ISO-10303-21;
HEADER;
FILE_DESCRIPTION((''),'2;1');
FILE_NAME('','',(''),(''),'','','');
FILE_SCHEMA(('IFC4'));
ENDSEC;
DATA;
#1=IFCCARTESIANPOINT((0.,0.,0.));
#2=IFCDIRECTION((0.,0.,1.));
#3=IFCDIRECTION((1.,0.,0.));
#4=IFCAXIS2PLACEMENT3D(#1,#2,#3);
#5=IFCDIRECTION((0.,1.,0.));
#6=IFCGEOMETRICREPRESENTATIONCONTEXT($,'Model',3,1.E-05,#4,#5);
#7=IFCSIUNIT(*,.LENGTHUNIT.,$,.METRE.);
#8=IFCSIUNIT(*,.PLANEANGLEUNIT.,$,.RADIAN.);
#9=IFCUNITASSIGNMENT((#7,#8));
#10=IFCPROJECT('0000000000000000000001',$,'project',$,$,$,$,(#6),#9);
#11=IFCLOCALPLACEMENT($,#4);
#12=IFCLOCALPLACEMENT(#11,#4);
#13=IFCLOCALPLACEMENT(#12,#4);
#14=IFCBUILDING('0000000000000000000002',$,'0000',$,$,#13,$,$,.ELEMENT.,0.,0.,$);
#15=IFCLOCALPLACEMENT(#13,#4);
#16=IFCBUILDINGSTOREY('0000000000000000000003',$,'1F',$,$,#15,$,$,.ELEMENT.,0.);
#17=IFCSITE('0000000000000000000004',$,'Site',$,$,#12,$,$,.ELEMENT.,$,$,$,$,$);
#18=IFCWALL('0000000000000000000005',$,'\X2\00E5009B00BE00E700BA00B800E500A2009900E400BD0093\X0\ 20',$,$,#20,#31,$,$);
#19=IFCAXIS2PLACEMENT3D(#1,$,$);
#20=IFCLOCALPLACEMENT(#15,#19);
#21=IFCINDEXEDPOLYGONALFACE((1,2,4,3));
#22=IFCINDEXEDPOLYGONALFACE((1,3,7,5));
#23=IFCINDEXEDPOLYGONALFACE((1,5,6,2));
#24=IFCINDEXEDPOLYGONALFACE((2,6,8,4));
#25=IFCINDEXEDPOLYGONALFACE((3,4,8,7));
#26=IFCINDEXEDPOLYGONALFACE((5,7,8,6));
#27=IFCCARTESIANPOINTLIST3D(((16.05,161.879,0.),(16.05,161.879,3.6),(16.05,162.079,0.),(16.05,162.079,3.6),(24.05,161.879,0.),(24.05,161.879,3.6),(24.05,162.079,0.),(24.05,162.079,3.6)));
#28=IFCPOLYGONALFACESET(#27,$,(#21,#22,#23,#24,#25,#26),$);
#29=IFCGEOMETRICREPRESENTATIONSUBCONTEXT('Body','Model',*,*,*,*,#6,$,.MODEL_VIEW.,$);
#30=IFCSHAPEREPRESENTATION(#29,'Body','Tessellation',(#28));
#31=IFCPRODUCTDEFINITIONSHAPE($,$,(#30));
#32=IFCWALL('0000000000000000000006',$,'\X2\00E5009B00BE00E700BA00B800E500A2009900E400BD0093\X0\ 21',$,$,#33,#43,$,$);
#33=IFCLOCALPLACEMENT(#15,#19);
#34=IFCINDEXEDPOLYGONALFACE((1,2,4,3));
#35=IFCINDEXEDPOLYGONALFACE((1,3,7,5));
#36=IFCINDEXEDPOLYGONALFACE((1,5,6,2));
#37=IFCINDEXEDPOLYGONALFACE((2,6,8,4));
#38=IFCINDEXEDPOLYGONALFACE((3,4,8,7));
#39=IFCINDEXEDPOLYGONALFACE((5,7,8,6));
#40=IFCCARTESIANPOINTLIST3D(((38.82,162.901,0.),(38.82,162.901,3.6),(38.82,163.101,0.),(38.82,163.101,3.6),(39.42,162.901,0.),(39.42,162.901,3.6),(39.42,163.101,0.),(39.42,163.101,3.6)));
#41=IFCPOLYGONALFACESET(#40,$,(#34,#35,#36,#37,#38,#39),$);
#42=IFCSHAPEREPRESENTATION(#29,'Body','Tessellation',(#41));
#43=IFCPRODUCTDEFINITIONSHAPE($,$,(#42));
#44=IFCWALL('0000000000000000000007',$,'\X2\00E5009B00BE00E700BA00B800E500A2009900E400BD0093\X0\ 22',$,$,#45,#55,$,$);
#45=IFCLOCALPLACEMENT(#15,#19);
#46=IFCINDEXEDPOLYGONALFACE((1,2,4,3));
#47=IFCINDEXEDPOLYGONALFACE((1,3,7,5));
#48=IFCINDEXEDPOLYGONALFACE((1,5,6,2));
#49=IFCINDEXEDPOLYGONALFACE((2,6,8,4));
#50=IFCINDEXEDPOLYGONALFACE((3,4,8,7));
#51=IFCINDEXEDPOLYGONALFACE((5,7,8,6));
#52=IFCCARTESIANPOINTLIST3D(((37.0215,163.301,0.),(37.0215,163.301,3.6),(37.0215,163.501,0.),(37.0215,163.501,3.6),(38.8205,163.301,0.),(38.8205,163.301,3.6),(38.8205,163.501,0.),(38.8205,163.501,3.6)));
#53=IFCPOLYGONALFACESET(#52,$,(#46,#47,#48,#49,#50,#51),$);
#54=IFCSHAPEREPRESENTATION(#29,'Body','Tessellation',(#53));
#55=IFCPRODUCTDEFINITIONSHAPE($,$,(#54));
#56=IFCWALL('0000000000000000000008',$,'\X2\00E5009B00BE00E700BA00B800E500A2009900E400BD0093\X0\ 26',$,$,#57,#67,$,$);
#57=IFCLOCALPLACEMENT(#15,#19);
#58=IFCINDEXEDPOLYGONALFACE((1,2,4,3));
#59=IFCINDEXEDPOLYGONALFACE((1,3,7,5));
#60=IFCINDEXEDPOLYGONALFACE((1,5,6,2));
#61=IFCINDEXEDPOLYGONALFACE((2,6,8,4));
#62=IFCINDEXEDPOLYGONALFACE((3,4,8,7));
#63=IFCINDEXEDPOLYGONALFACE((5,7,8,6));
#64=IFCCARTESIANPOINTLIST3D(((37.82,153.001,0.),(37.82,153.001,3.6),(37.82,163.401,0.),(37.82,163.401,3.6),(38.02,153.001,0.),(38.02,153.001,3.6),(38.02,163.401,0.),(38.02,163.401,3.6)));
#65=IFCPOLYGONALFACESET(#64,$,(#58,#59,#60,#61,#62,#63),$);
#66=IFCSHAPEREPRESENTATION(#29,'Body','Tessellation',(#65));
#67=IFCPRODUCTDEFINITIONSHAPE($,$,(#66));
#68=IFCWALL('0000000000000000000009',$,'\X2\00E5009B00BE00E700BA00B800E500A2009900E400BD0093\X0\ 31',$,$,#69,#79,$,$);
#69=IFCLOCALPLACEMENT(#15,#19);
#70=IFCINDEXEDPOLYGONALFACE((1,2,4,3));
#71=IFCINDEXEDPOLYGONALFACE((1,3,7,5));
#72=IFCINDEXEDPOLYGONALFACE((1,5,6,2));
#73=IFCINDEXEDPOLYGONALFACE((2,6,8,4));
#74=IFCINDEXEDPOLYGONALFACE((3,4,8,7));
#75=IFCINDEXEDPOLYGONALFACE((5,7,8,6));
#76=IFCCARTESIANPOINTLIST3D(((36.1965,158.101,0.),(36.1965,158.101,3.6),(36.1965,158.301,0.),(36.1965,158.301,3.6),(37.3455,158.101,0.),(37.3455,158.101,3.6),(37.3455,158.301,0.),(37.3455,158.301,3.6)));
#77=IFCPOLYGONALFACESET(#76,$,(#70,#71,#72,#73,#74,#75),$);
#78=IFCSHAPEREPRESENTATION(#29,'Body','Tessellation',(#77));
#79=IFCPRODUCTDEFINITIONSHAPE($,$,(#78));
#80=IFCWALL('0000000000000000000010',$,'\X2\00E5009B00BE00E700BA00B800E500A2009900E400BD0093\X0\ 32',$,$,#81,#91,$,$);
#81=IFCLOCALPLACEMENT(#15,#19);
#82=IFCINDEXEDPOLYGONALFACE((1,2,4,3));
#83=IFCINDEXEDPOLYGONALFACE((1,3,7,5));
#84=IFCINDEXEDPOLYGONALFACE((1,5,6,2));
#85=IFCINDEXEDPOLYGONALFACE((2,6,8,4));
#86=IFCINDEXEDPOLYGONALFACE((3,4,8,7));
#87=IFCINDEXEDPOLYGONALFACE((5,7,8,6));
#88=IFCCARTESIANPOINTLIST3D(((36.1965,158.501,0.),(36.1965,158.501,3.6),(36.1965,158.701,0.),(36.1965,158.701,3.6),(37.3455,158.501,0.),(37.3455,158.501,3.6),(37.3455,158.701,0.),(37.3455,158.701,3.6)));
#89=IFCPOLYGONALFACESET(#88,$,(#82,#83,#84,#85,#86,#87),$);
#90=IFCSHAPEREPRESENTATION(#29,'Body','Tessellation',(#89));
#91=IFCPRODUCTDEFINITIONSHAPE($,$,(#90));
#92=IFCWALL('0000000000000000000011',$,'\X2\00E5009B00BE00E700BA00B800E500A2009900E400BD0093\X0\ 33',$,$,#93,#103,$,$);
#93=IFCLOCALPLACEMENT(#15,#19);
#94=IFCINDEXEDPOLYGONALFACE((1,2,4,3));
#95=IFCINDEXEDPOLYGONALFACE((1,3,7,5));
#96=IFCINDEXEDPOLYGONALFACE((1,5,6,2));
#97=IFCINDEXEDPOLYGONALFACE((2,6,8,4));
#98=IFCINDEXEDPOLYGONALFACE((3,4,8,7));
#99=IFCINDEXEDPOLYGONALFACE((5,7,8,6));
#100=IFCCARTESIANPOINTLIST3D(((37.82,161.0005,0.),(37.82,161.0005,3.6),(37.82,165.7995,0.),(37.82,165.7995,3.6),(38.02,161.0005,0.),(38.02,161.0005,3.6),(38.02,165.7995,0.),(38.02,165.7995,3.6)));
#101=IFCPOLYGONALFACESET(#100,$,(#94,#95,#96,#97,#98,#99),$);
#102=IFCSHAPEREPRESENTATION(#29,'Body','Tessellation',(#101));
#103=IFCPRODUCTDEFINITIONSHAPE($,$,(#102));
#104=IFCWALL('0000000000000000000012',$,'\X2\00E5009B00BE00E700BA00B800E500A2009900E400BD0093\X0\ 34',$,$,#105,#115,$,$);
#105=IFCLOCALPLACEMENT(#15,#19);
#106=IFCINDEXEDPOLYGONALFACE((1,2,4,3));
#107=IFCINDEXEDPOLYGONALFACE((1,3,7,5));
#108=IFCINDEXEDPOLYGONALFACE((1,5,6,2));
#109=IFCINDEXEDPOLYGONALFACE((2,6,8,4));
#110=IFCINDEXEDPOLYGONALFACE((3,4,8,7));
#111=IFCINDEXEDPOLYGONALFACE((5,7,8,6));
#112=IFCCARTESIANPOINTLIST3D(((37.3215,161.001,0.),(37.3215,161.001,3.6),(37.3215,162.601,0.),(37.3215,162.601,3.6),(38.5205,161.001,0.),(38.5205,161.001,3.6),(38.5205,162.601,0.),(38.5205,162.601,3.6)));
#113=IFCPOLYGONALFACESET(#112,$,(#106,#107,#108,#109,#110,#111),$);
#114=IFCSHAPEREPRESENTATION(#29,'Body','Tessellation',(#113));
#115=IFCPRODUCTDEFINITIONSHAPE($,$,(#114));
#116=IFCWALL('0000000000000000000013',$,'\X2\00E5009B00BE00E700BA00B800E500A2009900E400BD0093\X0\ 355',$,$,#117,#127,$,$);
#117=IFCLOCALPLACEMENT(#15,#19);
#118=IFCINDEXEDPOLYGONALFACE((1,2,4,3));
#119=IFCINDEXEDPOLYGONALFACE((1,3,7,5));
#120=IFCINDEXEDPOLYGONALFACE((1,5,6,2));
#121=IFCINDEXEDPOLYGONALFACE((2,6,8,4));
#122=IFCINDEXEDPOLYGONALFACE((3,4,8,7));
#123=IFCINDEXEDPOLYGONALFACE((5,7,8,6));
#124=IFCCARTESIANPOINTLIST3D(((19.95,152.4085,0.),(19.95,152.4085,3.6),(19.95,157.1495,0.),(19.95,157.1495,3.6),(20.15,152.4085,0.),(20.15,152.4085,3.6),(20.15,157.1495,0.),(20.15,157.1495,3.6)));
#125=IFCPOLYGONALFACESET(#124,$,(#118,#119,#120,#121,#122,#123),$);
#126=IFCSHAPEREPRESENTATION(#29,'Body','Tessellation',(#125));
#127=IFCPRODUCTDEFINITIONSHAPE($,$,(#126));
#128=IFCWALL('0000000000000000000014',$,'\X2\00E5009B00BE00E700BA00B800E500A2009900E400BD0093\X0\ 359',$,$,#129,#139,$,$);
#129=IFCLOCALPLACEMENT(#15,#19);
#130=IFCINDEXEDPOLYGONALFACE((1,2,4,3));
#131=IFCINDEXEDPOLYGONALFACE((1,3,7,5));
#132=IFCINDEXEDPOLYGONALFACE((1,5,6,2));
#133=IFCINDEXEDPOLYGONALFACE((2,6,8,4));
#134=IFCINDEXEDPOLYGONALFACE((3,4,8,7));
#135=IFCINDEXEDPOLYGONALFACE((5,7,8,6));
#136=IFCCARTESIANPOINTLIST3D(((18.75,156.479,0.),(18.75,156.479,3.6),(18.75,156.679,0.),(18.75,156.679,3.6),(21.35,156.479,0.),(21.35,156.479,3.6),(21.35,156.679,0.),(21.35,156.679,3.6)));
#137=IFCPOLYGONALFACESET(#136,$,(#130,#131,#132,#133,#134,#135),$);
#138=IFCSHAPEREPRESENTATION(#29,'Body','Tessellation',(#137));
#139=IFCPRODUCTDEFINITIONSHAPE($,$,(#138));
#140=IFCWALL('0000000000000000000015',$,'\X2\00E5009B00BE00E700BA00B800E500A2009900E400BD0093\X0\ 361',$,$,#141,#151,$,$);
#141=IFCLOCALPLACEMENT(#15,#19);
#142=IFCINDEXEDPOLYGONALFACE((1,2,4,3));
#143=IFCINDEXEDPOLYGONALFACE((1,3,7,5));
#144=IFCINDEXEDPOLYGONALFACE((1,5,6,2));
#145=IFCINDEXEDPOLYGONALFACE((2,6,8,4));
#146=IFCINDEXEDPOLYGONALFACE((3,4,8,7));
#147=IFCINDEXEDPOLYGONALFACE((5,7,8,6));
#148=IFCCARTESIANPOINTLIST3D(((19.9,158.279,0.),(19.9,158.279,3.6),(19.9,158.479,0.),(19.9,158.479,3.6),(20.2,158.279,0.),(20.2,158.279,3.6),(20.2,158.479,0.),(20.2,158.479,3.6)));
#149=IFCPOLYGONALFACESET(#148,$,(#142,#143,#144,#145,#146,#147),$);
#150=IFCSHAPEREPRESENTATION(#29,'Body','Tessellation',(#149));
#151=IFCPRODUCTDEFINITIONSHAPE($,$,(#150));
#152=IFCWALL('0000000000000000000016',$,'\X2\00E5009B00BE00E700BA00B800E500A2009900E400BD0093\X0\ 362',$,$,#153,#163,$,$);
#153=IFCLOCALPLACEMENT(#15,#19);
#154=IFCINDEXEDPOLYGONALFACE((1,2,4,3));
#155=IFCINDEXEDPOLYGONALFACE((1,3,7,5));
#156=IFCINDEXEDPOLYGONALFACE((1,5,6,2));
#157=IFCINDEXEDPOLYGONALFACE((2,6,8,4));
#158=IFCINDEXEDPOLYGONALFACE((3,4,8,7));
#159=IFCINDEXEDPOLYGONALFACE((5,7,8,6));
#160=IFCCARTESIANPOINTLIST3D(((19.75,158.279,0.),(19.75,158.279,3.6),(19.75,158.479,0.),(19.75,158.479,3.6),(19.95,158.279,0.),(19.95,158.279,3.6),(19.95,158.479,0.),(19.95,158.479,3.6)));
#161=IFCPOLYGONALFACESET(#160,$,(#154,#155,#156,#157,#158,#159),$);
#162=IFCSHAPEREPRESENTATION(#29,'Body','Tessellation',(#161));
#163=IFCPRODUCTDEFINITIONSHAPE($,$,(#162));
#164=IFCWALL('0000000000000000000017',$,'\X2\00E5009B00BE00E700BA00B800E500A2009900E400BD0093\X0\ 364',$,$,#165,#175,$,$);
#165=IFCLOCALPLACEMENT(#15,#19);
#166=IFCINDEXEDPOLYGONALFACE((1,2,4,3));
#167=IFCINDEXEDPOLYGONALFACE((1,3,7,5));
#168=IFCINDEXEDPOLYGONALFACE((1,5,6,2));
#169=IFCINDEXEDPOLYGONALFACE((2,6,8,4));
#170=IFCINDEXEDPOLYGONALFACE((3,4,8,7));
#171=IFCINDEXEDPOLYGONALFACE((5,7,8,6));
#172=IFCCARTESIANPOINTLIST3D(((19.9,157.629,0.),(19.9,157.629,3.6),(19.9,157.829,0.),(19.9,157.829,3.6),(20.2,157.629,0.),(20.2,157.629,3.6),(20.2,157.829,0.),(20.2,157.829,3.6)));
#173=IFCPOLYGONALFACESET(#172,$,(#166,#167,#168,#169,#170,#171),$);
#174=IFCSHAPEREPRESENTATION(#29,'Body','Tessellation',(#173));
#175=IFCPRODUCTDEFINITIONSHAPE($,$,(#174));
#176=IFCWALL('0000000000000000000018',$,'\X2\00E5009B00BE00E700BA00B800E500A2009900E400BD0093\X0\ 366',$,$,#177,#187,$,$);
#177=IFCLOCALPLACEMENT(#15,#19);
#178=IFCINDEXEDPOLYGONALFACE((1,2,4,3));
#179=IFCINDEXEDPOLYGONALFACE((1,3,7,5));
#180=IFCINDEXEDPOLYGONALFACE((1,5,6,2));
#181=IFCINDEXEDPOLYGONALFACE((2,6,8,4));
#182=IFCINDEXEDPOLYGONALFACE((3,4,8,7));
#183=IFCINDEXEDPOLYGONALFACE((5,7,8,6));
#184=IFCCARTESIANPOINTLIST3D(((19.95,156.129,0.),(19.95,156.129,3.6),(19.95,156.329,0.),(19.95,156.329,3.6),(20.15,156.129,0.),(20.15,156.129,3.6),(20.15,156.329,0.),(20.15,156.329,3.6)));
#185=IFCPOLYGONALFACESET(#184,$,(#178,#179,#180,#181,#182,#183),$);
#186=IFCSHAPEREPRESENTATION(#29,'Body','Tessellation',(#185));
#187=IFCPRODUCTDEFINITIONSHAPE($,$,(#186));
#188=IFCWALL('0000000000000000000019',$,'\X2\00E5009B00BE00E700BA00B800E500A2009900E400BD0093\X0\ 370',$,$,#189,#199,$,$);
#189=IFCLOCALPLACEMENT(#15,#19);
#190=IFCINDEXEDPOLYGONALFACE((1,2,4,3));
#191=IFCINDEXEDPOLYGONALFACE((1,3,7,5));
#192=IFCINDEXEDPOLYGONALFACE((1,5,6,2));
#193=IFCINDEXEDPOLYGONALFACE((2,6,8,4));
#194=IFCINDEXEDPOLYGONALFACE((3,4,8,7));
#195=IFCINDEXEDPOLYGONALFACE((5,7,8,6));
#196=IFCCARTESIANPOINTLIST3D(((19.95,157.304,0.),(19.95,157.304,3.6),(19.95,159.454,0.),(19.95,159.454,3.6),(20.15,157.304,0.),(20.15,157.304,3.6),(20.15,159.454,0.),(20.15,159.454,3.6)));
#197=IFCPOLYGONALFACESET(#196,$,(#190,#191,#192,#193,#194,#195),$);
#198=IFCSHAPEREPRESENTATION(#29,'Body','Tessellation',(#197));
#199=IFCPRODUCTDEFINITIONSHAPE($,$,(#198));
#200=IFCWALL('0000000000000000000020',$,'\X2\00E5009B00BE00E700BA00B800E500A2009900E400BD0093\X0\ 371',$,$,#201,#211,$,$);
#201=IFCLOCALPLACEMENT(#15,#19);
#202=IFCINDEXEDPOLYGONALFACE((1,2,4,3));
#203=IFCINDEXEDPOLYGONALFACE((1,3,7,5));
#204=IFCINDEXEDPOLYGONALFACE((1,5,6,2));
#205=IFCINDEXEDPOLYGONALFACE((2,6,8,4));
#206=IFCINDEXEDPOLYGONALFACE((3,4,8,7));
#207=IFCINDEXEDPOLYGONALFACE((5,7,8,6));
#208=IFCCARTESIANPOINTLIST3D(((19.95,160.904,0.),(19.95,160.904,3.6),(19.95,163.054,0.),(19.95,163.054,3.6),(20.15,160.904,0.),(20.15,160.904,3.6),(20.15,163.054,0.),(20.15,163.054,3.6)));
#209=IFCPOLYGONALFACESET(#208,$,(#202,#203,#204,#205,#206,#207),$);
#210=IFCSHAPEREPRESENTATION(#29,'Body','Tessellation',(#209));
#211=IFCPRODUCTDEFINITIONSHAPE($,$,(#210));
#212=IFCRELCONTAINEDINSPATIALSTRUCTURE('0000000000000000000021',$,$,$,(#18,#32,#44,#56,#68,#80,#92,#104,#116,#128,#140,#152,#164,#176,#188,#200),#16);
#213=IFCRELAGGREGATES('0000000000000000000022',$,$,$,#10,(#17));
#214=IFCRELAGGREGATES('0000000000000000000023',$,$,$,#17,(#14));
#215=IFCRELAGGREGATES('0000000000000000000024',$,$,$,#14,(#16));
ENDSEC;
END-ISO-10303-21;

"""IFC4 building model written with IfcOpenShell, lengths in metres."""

from ifc_helpers import new_model, si_unit, direction, frame, frame_2d, origin_with_axes, place, context, subcontext, project, spatial, rectangle, extrude, element, save


model = new_model("IFC4")

# Units and contexts
model_context = context("Model", 3, precision=1e-05, world=origin_with_axes(), true_north=direction((0.0, 1.0, 0.0)))
body_context = subcontext(model_context, "Body", "Model", "MODEL_VIEW")
ifc_project = project(units=[si_unit("LENGTHUNIT", "METRE"), si_unit("PLANEANGLEUNIT", "RADIAN")], contexts=[model_context])

# Site, building, storey
placement = place(None, origin_with_axes())
site_placement = place(placement, origin_with_axes())
site = spatial("IfcSite", under=ifc_project, at=site_placement, Name="Site", CompositionType="ELEMENT")
building_placement = place(site_placement, origin_with_axes())
building = spatial("IfcBuilding", under=site, at=building_placement, Name="0000", CompositionType="ELEMENT", ElevationOfRefHeight=0.0, ElevationOfTerrain=0.0)
storey_placement = place(building_placement, origin_with_axes())
storey = spatial("IfcBuildingStorey", under=building, at=storey_placement, Name="1F", CompositionType="ELEMENT", Elevation=0.0)

# Walls
wall_1_placement = place(storey_placement, frame((20.05, 161.979, 0.0), z_axis=(0.0, 0.0, 1.0), x_axis=(-1.0, 0.0, 0.0)))
element("IfcWall", 1, at=wall_1_placement, inside=storey, Name="å\u009b¾çº¸å¢\u0099ä½\u0093 20", context=body_context, shape_type="SweptSolid", body=[
    extrude(rectangle(XDim=8.0, YDim=0.2, at=frame_2d((0.0, 0.0), x_axis=(1.0, 0.0, 0.0))), frame((0.0, 0.0, 0.0), z_axis=(0.0, 0.0, 1.0)), (0.0, 0.0, 1.0), 3.6),
])
wall_2_placement = place(storey_placement, frame((39.12, 163.001, 0.0), z_axis=(0.0, 0.0, 1.0), x_axis=(1.0, 0.0, 0.0)))
element("IfcWall", 2, at=wall_2_placement, inside=storey, Name="å\u009b¾çº¸å¢\u0099ä½\u0093 21", context=body_context, shape_type="SweptSolid", body=[
    extrude(rectangle(XDim=0.6, YDim=0.2, at=frame_2d((0.0, 0.0), x_axis=(1.0, 0.0, 0.0))), frame((0.0, 0.0, 0.0), z_axis=(0.0, 0.0, 1.0)), (0.0, 0.0, 1.0), 3.6),
])
wall_3_placement = place(storey_placement, frame((37.921, 163.401, 0.0), z_axis=(0.0, 0.0, 1.0), x_axis=(1.0, 0.0, 0.0)))
element("IfcWall", 3, at=wall_3_placement, inside=storey, Name="å\u009b¾çº¸å¢\u0099ä½\u0093 22", context=body_context, shape_type="SweptSolid", body=[
    extrude(rectangle(XDim=1.799, YDim=0.2, at=frame_2d((0.0, 0.0), x_axis=(1.0, 0.0, 0.0))), frame((0.0, 0.0, 0.0), z_axis=(0.0, 0.0, 1.0)), (0.0, 0.0, 1.0), 3.6),
])
wall_4_placement = place(storey_placement, frame((37.92, 158.201, 0.0), z_axis=(0.0, 0.0, 1.0), x_axis=(0.0, -1.0, 0.0)))
element("IfcWall", 4, at=wall_4_placement, inside=storey, Name="å\u009b¾çº¸å¢\u0099ä½\u0093 26", context=body_context, shape_type="SweptSolid", body=[
    extrude(rectangle(XDim=10.4, YDim=0.2, at=frame_2d((0.0, 0.0), x_axis=(1.0, 0.0, 0.0))), frame((0.0, 0.0, 0.0), z_axis=(0.0, 0.0, 1.0)), (0.0, 0.0, 1.0), 3.6),
])
for number, where, z_axis, x_axis, name in (
    (5, (36.771, 158.201, 0.0), (0.0, 0.0, 1.0), (1.0, 0.0, 0.0), "å\u009b¾çº¸å¢\u0099ä½\u0093 31"),
    (6, (36.771, 158.601, 0.0), (0.0, 0.0, 1.0), (1.0, 0.0, 0.0), "å\u009b¾çº¸å¢\u0099ä½\u0093 32"),
):
    element("IfcWall", number, at=place(storey_placement, frame(where, z_axis=z_axis, x_axis=x_axis)), inside=storey, Name=name, context=body_context, shape_type="SweptSolid", body=[
        extrude(rectangle(XDim=1.149, YDim=0.2, at=frame_2d((0.0, 0.0), x_axis=(1.0, 0.0, 0.0))), frame((0.0, 0.0, 0.0), z_axis=(0.0, 0.0, 1.0)), (0.0, 0.0, 1.0), 3.6),
    ])
wall_5_placement = place(storey_placement, frame((37.92, 163.4, 0.0), z_axis=(0.0, 0.0, 1.0), x_axis=(0.0, -1.0, 0.0)))
element("IfcWall", 7, at=wall_5_placement, inside=storey, Name="å\u009b¾çº¸å¢\u0099ä½\u0093 33", context=body_context, shape_type="SweptSolid", body=[
    extrude(rectangle(XDim=4.799, YDim=0.2, at=frame_2d((0.0, 0.0), x_axis=(1.0, 0.0, 0.0))), frame((0.0, 0.0, 0.0), z_axis=(0.0, 0.0, 1.0)), (0.0, 0.0, 1.0), 3.6),
])
wall_6_placement = place(storey_placement, frame((37.921, 161.801, 0.0), z_axis=(0.0, 0.0, 1.0), x_axis=(1.0, 0.0, 0.0)))
element("IfcWall", 8, at=wall_6_placement, inside=storey, Name="å\u009b¾çº¸å¢\u0099ä½\u0093 34", context=body_context, shape_type="SweptSolid", body=[
    extrude(rectangle(XDim=1.199, YDim=1.6, at=frame_2d((0.0, 0.0), x_axis=(1.0, 0.0, 0.0))), frame((0.0, 0.0, 0.0), z_axis=(0.0, 0.0, 1.0)), (0.0, 0.0, 1.0), 3.6),
])
wall_7_placement = place(storey_placement, frame((20.05, 154.779, 0.0), z_axis=(0.0, 0.0, 1.0), x_axis=(0.0, -1.0, 0.0)))
element("IfcWall", 9, at=wall_7_placement, inside=storey, Name="å\u009b¾çº¸å¢\u0099ä½\u0093 355", context=body_context, shape_type="SweptSolid", body=[
    extrude(rectangle(XDim=4.741, YDim=0.2, at=frame_2d((0.0, 0.0), x_axis=(1.0, 0.0, 0.0))), frame((0.0, 0.0, 0.0), z_axis=(0.0, 0.0, 1.0)), (0.0, 0.0, 1.0), 3.6),
])
wall_8_placement = place(storey_placement, frame((20.05, 156.579, 0.0), z_axis=(0.0, 0.0, 1.0), x_axis=(-1.0, 0.0, 0.0)))
element("IfcWall", 10, at=wall_8_placement, inside=storey, Name="å\u009b¾çº¸å¢\u0099ä½\u0093 359", context=body_context, shape_type="SweptSolid", body=[
    extrude(rectangle(XDim=2.6, YDim=0.2, at=frame_2d((0.0, 0.0), x_axis=(1.0, 0.0, 0.0))), frame((0.0, 0.0, 0.0), z_axis=(0.0, 0.0, 1.0)), (0.0, 0.0, 1.0), 3.6),
])
wall_9_placement = place(storey_placement, frame((20.05, 158.379, 0.0), z_axis=(0.0, 0.0, 1.0), x_axis=(-1.0, 0.0, 0.0)))
element("IfcWall", 11, at=wall_9_placement, inside=storey, Name="å\u009b¾çº¸å¢\u0099ä½\u0093 361", context=body_context, shape_type="SweptSolid", body=[
    extrude(rectangle(XDim=0.3, YDim=0.2, at=frame_2d((0.0, 0.0), x_axis=(1.0, 0.0, 0.0))), frame((0.0, 0.0, 0.0), z_axis=(0.0, 0.0, 1.0)), (0.0, 0.0, 1.0), 3.6),
])
wall_10_placement = place(storey_placement, frame((19.85, 158.379, 0.0), z_axis=(0.0, 0.0, 1.0), x_axis=(1.0, 0.0, 0.0)))
element("IfcWall", 12, at=wall_10_placement, inside=storey, Name="å\u009b¾çº¸å¢\u0099ä½\u0093 362", context=body_context, shape_type="SweptSolid", body=[
    extrude(rectangle(XDim=0.2, YDim=0.2, at=frame_2d((0.0, 0.0), x_axis=(1.0, 0.0, 0.0))), frame((0.0, 0.0, 0.0), z_axis=(0.0, 0.0, 1.0)), (0.0, 0.0, 1.0), 3.6),
])
for number, where, z_axis, x_axis, name in (
    (13, (20.05, 157.729, 0.0), (0.0, 0.0, 1.0), (-1.0, 0.0, 0.0), "å\u009b¾çº¸å¢\u0099ä½\u0093 364"),
):
    element("IfcWall", number, at=place(storey_placement, frame(where, z_axis=z_axis, x_axis=x_axis)), inside=storey, Name=name, context=body_context, shape_type="SweptSolid", body=[
        extrude(rectangle(XDim=0.3, YDim=0.2, at=frame_2d((0.0, 0.0), x_axis=(1.0, 0.0, 0.0))), frame((0.0, 0.0, 0.0), z_axis=(0.0, 0.0, 1.0)), (0.0, 0.0, 1.0), 3.6),
    ])
wall_11_placement = place(storey_placement, frame((20.05, 156.229, 0.0), z_axis=(0.0, 0.0, 1.0), x_axis=(-1.0, 0.0, 0.0)))
element("IfcWall", 14, at=wall_11_placement, inside=storey, Name="å\u009b¾çº¸å¢\u0099ä½\u0093 366", context=body_context, shape_type="SweptSolid", body=[
    extrude(rectangle(XDim=0.2, YDim=0.2, at=frame_2d((0.0, 0.0), x_axis=(1.0, 0.0, 0.0))), frame((0.0, 0.0, 0.0), z_axis=(0.0, 0.0, 1.0)), (0.0, 0.0, 1.0), 3.6),
])
for number, where, z_axis, x_axis, name in (
    (15, (20.05, 158.379, 0.0), (0.0, 0.0, 1.0), (0.0, -1.0, 0.0), "å\u009b¾çº¸å¢\u0099ä½\u0093 370"),
    (16, (20.05, 161.979, 0.0), (0.0, 0.0, 1.0), (0.0, -1.0, 0.0), "å\u009b¾çº¸å¢\u0099ä½\u0093 371"),
):
    element("IfcWall", number, at=place(storey_placement, frame(where, z_axis=z_axis, x_axis=x_axis)), inside=storey, Name=name, context=body_context, shape_type="SweptSolid", body=[
        extrude(rectangle(XDim=2.15, YDim=0.2, at=frame_2d((0.0, 0.0), x_axis=(1.0, 0.0, 0.0))), frame((0.0, 0.0, 0.0), z_axis=(0.0, 0.0, 1.0)), (0.0, 0.0, 1.0), 3.6),
    ])

save(model, "model.ifc")
